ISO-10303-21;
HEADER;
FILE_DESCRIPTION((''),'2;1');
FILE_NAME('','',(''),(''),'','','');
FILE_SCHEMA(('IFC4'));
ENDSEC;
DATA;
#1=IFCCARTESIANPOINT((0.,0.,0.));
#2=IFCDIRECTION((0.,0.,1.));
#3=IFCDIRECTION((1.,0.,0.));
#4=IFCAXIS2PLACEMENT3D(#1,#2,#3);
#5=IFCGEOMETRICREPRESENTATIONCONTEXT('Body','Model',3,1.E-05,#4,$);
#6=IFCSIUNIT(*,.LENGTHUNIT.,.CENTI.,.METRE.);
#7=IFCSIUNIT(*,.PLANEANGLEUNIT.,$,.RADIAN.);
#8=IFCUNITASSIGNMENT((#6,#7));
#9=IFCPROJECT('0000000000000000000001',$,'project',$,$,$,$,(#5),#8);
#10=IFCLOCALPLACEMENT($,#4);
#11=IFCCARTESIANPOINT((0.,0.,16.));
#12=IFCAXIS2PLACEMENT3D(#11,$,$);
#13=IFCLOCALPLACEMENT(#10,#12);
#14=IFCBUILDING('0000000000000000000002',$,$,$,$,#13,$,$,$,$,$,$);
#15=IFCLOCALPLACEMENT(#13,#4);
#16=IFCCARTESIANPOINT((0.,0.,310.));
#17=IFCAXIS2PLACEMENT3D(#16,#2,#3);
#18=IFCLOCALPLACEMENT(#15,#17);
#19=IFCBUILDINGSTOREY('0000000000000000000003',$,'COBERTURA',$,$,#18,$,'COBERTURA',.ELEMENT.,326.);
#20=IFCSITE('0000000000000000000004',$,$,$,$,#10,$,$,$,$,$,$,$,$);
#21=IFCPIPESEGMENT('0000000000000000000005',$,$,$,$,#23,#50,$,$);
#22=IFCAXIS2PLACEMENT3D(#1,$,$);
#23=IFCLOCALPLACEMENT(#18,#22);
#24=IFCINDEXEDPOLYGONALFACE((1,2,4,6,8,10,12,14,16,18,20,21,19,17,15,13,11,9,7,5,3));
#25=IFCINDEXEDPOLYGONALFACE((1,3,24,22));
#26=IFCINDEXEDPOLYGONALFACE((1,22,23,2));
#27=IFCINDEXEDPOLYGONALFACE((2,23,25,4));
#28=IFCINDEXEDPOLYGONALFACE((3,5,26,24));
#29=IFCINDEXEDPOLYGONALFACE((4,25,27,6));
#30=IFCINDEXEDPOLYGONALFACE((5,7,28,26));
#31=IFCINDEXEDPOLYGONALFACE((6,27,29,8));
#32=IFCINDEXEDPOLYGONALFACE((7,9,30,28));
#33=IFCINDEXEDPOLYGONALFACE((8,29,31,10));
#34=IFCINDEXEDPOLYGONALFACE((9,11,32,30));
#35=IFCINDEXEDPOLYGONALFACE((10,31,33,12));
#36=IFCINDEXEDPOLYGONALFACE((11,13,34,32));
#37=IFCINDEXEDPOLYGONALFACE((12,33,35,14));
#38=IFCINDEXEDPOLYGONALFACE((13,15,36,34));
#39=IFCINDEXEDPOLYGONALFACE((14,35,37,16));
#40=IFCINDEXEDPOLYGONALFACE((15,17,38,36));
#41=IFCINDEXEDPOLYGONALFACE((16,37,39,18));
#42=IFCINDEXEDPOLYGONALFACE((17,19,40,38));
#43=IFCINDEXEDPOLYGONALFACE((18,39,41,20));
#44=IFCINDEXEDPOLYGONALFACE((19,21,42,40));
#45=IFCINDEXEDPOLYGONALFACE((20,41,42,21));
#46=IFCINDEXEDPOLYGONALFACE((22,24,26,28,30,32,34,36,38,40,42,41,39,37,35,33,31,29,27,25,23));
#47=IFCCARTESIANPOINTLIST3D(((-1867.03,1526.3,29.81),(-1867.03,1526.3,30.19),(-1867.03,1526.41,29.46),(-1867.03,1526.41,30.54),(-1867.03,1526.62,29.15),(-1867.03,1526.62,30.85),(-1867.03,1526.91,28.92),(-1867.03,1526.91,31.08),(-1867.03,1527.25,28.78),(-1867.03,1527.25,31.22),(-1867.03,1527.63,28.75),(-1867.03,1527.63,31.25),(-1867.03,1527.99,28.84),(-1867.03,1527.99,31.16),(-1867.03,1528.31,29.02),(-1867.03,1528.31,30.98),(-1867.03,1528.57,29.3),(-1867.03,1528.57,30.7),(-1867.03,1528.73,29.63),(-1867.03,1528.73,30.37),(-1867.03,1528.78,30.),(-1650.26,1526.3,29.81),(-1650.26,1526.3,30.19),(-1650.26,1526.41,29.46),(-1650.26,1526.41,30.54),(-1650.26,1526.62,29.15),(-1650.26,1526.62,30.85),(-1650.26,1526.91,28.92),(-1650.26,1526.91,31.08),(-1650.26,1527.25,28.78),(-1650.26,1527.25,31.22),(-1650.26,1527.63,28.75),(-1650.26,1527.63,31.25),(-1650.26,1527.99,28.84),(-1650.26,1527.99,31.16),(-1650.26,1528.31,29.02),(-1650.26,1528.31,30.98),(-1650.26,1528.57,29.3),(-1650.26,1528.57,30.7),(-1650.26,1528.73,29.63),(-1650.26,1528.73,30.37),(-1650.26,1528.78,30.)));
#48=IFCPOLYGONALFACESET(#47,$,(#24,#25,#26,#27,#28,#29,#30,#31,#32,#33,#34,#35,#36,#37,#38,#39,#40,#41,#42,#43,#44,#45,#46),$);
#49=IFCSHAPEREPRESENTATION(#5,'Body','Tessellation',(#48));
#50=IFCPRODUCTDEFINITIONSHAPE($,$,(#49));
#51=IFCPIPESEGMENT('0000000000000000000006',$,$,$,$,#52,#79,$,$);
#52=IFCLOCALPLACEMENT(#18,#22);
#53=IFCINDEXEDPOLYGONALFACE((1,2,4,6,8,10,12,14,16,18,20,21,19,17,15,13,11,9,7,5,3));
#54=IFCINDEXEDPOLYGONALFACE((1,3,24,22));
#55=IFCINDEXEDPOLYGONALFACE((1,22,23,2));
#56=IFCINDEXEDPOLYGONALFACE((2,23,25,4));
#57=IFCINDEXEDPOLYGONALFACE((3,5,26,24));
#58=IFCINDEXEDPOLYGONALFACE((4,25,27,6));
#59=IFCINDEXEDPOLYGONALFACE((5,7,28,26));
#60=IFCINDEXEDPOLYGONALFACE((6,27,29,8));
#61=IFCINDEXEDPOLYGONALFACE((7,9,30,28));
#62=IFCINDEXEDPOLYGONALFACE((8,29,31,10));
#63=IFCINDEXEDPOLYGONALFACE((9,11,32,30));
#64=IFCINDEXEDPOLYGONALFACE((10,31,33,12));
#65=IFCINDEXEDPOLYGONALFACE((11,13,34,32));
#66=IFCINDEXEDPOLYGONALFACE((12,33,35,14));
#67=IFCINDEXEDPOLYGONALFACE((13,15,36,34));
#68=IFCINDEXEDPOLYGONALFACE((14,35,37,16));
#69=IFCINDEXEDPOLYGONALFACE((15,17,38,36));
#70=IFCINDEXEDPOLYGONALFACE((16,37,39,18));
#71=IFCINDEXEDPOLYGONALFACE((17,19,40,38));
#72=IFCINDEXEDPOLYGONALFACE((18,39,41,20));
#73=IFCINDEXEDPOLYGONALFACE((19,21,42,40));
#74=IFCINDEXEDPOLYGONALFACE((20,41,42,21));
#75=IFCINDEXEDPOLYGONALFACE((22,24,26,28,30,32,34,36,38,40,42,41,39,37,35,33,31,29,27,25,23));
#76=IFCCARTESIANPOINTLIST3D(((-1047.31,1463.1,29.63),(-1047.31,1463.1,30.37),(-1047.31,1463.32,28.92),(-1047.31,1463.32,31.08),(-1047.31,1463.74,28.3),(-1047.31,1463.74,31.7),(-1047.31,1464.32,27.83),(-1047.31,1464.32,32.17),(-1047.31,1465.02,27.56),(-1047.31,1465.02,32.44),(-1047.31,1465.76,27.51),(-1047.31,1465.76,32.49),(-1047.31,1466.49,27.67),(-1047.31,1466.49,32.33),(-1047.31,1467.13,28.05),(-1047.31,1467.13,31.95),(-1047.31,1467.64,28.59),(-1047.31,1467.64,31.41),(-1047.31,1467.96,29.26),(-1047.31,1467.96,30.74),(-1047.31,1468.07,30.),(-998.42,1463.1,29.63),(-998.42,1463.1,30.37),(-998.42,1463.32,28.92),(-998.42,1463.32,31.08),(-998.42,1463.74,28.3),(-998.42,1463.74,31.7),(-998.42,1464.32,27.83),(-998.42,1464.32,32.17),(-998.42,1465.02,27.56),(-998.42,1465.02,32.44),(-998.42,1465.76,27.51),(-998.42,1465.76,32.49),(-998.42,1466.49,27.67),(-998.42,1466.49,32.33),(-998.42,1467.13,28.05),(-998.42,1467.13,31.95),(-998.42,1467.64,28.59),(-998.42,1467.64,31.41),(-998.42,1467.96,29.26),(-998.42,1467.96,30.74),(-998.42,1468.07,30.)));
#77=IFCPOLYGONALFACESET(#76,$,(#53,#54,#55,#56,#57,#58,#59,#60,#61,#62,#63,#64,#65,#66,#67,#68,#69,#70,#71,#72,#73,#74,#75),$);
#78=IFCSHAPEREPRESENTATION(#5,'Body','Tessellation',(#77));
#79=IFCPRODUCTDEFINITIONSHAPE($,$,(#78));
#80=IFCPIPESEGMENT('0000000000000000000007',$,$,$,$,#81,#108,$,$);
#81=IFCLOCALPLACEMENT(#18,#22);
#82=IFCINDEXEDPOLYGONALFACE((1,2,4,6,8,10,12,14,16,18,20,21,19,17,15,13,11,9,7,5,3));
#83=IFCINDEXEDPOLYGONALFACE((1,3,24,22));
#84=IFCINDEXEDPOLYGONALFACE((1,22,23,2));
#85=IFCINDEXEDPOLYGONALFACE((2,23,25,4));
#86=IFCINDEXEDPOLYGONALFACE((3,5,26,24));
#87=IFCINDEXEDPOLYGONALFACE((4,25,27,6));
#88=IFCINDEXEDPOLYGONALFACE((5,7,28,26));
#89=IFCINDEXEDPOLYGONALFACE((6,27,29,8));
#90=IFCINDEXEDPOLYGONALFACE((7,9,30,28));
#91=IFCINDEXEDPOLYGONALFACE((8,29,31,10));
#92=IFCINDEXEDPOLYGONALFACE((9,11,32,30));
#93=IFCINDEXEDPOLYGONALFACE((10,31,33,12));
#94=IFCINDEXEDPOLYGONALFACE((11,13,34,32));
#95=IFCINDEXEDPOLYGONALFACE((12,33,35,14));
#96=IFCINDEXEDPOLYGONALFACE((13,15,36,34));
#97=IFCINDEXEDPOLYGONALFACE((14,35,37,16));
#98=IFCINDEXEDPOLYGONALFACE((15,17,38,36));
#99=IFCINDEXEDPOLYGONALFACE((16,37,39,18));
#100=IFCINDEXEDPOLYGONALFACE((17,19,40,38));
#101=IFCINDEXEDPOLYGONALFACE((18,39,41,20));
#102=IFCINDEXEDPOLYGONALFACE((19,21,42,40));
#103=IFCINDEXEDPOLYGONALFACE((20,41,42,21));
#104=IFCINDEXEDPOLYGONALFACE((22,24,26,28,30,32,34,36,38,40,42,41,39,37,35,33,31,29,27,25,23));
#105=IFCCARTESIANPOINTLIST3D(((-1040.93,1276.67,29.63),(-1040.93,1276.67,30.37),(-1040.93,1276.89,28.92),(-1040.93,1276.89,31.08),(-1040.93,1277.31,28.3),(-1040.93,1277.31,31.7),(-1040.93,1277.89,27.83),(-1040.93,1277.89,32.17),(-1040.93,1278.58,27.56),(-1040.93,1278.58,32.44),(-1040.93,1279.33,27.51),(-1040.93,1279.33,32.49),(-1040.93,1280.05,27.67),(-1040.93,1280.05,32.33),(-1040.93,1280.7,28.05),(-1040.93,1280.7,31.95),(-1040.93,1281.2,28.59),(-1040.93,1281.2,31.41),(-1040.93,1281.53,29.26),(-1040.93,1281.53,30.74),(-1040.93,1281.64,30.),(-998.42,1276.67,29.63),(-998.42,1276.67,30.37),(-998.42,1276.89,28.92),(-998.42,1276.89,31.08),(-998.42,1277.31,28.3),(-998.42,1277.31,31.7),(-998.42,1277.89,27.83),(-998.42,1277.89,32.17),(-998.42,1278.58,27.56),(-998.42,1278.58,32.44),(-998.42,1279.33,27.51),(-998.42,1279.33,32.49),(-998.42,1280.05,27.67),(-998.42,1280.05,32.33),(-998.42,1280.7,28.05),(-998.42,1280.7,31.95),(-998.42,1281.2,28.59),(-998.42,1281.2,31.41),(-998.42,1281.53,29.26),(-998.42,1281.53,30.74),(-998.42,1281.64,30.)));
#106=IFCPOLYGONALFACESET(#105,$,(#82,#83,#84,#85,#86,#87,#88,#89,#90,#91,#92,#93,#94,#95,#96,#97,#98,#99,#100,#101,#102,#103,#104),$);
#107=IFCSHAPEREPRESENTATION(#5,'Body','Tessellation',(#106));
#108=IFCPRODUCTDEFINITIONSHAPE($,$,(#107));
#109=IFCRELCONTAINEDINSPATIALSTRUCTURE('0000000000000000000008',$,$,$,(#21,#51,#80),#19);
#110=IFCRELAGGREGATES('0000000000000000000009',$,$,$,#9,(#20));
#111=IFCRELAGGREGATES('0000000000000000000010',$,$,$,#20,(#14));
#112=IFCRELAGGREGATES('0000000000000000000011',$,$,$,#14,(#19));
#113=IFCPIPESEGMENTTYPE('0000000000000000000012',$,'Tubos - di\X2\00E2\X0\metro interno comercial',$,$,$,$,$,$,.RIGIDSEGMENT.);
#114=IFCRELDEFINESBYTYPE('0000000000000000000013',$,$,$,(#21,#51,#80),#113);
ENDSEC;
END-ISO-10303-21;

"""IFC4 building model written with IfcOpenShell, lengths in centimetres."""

from ifc_helpers import new_model, si_unit, frame, origin_with_axes, origin_2d_with_axis, place, context, project, spatial, circle, extrude, type_object, element, save


model = new_model("IFC4")

# Units and contexts
model_context = context("Model", 3, precision=1e-05, world=origin_with_axes(), identifier="Body")
ifc_project = project(units=[si_unit("LENGTHUNIT", "METRE", prefix="CENTI"), si_unit("PLANEANGLEUNIT", "RADIAN")], contexts=[model_context])

# Site, building, storey
site_placement = place(None, origin_with_axes())
site = spatial("IfcSite", under=ifc_project, at=site_placement)
building_placement = place(site_placement, frame((0.0, 0.0, 16.0)))
building = spatial("IfcBuilding", under=site, at=building_placement)
placement = place(building_placement, origin_with_axes())
storey_placement = place(placement, frame((0.0, 0.0, 310.0), z_axis=(0.0, 0.0, 1.0), x_axis=(1.0, 0.0, 0.0)))
storey = spatial("IfcBuildingStorey", under=building, at=storey_placement, Name="COBERTURA", LongName="COBERTURA", CompositionType="ELEMENT", Elevation=326.0)

# Pipe segments
pipe_segment_type = type_object("IfcPipeSegmentType", Name="Tubos - diâmetro interno comercial", PredefinedType="RIGIDSEGMENT")
pipe_segment_1_placement = place(storey_placement, frame((-1758.65, 1527.53, 31.25), z_axis=(0.0, 0.0, 1.0), x_axis=(1.0, 0.0, 0.0)))
element("IfcPipeSegment", 1, at=pipe_segment_1_placement, inside=storey, type_object=pipe_segment_type, context=model_context, shape_type="SolidModel", body=[
    extrude(circle(Radius=1.25, at=origin_2d_with_axis()), frame((108.38, 0.0, -1.25), z_axis=(-1.0, 0.0, 0.0), x_axis=(0.0, 1.0, 0.0)), (0.0, 0.0, 1.0), 216.77),
])
pipe_segment_2_placement = place(storey_placement, frame((-1022.87, 1465.57, 32.5), z_axis=(0.0, 0.0, 1.0), x_axis=(1.0, 0.0, 0.0)))
element("IfcPipeSegment", 2, at=pipe_segment_2_placement, inside=storey, type_object=pipe_segment_type, context=model_context, shape_type="SolidModel", body=[
    extrude(circle(Radius=2.5, at=origin_2d_with_axis()), frame((-24.45, 0.0, -2.5), z_axis=(1.0, 0.0, 0.0), x_axis=(0.0, 1.0, 0.0)), (0.0, 0.0, 1.0), 48.89),
])
pipe_segment_3_placement = place(storey_placement, frame((-1019.68, 1279.14, 32.5), z_axis=(0.0, 0.0, 1.0), x_axis=(1.0, 0.0, 0.0)))
element("IfcPipeSegment", 3, at=pipe_segment_3_placement, inside=storey, type_object=pipe_segment_type, context=model_context, shape_type="SolidModel", body=[
    extrude(circle(Radius=2.5, at=origin_2d_with_axis()), frame((-21.26, 0.0, -2.5), z_axis=(1.0, 0.0, 0.0), x_axis=(0.0, 1.0, 0.0)), (0.0, 0.0, 1.0), 42.51),
])

save(model, "model.ifc")
